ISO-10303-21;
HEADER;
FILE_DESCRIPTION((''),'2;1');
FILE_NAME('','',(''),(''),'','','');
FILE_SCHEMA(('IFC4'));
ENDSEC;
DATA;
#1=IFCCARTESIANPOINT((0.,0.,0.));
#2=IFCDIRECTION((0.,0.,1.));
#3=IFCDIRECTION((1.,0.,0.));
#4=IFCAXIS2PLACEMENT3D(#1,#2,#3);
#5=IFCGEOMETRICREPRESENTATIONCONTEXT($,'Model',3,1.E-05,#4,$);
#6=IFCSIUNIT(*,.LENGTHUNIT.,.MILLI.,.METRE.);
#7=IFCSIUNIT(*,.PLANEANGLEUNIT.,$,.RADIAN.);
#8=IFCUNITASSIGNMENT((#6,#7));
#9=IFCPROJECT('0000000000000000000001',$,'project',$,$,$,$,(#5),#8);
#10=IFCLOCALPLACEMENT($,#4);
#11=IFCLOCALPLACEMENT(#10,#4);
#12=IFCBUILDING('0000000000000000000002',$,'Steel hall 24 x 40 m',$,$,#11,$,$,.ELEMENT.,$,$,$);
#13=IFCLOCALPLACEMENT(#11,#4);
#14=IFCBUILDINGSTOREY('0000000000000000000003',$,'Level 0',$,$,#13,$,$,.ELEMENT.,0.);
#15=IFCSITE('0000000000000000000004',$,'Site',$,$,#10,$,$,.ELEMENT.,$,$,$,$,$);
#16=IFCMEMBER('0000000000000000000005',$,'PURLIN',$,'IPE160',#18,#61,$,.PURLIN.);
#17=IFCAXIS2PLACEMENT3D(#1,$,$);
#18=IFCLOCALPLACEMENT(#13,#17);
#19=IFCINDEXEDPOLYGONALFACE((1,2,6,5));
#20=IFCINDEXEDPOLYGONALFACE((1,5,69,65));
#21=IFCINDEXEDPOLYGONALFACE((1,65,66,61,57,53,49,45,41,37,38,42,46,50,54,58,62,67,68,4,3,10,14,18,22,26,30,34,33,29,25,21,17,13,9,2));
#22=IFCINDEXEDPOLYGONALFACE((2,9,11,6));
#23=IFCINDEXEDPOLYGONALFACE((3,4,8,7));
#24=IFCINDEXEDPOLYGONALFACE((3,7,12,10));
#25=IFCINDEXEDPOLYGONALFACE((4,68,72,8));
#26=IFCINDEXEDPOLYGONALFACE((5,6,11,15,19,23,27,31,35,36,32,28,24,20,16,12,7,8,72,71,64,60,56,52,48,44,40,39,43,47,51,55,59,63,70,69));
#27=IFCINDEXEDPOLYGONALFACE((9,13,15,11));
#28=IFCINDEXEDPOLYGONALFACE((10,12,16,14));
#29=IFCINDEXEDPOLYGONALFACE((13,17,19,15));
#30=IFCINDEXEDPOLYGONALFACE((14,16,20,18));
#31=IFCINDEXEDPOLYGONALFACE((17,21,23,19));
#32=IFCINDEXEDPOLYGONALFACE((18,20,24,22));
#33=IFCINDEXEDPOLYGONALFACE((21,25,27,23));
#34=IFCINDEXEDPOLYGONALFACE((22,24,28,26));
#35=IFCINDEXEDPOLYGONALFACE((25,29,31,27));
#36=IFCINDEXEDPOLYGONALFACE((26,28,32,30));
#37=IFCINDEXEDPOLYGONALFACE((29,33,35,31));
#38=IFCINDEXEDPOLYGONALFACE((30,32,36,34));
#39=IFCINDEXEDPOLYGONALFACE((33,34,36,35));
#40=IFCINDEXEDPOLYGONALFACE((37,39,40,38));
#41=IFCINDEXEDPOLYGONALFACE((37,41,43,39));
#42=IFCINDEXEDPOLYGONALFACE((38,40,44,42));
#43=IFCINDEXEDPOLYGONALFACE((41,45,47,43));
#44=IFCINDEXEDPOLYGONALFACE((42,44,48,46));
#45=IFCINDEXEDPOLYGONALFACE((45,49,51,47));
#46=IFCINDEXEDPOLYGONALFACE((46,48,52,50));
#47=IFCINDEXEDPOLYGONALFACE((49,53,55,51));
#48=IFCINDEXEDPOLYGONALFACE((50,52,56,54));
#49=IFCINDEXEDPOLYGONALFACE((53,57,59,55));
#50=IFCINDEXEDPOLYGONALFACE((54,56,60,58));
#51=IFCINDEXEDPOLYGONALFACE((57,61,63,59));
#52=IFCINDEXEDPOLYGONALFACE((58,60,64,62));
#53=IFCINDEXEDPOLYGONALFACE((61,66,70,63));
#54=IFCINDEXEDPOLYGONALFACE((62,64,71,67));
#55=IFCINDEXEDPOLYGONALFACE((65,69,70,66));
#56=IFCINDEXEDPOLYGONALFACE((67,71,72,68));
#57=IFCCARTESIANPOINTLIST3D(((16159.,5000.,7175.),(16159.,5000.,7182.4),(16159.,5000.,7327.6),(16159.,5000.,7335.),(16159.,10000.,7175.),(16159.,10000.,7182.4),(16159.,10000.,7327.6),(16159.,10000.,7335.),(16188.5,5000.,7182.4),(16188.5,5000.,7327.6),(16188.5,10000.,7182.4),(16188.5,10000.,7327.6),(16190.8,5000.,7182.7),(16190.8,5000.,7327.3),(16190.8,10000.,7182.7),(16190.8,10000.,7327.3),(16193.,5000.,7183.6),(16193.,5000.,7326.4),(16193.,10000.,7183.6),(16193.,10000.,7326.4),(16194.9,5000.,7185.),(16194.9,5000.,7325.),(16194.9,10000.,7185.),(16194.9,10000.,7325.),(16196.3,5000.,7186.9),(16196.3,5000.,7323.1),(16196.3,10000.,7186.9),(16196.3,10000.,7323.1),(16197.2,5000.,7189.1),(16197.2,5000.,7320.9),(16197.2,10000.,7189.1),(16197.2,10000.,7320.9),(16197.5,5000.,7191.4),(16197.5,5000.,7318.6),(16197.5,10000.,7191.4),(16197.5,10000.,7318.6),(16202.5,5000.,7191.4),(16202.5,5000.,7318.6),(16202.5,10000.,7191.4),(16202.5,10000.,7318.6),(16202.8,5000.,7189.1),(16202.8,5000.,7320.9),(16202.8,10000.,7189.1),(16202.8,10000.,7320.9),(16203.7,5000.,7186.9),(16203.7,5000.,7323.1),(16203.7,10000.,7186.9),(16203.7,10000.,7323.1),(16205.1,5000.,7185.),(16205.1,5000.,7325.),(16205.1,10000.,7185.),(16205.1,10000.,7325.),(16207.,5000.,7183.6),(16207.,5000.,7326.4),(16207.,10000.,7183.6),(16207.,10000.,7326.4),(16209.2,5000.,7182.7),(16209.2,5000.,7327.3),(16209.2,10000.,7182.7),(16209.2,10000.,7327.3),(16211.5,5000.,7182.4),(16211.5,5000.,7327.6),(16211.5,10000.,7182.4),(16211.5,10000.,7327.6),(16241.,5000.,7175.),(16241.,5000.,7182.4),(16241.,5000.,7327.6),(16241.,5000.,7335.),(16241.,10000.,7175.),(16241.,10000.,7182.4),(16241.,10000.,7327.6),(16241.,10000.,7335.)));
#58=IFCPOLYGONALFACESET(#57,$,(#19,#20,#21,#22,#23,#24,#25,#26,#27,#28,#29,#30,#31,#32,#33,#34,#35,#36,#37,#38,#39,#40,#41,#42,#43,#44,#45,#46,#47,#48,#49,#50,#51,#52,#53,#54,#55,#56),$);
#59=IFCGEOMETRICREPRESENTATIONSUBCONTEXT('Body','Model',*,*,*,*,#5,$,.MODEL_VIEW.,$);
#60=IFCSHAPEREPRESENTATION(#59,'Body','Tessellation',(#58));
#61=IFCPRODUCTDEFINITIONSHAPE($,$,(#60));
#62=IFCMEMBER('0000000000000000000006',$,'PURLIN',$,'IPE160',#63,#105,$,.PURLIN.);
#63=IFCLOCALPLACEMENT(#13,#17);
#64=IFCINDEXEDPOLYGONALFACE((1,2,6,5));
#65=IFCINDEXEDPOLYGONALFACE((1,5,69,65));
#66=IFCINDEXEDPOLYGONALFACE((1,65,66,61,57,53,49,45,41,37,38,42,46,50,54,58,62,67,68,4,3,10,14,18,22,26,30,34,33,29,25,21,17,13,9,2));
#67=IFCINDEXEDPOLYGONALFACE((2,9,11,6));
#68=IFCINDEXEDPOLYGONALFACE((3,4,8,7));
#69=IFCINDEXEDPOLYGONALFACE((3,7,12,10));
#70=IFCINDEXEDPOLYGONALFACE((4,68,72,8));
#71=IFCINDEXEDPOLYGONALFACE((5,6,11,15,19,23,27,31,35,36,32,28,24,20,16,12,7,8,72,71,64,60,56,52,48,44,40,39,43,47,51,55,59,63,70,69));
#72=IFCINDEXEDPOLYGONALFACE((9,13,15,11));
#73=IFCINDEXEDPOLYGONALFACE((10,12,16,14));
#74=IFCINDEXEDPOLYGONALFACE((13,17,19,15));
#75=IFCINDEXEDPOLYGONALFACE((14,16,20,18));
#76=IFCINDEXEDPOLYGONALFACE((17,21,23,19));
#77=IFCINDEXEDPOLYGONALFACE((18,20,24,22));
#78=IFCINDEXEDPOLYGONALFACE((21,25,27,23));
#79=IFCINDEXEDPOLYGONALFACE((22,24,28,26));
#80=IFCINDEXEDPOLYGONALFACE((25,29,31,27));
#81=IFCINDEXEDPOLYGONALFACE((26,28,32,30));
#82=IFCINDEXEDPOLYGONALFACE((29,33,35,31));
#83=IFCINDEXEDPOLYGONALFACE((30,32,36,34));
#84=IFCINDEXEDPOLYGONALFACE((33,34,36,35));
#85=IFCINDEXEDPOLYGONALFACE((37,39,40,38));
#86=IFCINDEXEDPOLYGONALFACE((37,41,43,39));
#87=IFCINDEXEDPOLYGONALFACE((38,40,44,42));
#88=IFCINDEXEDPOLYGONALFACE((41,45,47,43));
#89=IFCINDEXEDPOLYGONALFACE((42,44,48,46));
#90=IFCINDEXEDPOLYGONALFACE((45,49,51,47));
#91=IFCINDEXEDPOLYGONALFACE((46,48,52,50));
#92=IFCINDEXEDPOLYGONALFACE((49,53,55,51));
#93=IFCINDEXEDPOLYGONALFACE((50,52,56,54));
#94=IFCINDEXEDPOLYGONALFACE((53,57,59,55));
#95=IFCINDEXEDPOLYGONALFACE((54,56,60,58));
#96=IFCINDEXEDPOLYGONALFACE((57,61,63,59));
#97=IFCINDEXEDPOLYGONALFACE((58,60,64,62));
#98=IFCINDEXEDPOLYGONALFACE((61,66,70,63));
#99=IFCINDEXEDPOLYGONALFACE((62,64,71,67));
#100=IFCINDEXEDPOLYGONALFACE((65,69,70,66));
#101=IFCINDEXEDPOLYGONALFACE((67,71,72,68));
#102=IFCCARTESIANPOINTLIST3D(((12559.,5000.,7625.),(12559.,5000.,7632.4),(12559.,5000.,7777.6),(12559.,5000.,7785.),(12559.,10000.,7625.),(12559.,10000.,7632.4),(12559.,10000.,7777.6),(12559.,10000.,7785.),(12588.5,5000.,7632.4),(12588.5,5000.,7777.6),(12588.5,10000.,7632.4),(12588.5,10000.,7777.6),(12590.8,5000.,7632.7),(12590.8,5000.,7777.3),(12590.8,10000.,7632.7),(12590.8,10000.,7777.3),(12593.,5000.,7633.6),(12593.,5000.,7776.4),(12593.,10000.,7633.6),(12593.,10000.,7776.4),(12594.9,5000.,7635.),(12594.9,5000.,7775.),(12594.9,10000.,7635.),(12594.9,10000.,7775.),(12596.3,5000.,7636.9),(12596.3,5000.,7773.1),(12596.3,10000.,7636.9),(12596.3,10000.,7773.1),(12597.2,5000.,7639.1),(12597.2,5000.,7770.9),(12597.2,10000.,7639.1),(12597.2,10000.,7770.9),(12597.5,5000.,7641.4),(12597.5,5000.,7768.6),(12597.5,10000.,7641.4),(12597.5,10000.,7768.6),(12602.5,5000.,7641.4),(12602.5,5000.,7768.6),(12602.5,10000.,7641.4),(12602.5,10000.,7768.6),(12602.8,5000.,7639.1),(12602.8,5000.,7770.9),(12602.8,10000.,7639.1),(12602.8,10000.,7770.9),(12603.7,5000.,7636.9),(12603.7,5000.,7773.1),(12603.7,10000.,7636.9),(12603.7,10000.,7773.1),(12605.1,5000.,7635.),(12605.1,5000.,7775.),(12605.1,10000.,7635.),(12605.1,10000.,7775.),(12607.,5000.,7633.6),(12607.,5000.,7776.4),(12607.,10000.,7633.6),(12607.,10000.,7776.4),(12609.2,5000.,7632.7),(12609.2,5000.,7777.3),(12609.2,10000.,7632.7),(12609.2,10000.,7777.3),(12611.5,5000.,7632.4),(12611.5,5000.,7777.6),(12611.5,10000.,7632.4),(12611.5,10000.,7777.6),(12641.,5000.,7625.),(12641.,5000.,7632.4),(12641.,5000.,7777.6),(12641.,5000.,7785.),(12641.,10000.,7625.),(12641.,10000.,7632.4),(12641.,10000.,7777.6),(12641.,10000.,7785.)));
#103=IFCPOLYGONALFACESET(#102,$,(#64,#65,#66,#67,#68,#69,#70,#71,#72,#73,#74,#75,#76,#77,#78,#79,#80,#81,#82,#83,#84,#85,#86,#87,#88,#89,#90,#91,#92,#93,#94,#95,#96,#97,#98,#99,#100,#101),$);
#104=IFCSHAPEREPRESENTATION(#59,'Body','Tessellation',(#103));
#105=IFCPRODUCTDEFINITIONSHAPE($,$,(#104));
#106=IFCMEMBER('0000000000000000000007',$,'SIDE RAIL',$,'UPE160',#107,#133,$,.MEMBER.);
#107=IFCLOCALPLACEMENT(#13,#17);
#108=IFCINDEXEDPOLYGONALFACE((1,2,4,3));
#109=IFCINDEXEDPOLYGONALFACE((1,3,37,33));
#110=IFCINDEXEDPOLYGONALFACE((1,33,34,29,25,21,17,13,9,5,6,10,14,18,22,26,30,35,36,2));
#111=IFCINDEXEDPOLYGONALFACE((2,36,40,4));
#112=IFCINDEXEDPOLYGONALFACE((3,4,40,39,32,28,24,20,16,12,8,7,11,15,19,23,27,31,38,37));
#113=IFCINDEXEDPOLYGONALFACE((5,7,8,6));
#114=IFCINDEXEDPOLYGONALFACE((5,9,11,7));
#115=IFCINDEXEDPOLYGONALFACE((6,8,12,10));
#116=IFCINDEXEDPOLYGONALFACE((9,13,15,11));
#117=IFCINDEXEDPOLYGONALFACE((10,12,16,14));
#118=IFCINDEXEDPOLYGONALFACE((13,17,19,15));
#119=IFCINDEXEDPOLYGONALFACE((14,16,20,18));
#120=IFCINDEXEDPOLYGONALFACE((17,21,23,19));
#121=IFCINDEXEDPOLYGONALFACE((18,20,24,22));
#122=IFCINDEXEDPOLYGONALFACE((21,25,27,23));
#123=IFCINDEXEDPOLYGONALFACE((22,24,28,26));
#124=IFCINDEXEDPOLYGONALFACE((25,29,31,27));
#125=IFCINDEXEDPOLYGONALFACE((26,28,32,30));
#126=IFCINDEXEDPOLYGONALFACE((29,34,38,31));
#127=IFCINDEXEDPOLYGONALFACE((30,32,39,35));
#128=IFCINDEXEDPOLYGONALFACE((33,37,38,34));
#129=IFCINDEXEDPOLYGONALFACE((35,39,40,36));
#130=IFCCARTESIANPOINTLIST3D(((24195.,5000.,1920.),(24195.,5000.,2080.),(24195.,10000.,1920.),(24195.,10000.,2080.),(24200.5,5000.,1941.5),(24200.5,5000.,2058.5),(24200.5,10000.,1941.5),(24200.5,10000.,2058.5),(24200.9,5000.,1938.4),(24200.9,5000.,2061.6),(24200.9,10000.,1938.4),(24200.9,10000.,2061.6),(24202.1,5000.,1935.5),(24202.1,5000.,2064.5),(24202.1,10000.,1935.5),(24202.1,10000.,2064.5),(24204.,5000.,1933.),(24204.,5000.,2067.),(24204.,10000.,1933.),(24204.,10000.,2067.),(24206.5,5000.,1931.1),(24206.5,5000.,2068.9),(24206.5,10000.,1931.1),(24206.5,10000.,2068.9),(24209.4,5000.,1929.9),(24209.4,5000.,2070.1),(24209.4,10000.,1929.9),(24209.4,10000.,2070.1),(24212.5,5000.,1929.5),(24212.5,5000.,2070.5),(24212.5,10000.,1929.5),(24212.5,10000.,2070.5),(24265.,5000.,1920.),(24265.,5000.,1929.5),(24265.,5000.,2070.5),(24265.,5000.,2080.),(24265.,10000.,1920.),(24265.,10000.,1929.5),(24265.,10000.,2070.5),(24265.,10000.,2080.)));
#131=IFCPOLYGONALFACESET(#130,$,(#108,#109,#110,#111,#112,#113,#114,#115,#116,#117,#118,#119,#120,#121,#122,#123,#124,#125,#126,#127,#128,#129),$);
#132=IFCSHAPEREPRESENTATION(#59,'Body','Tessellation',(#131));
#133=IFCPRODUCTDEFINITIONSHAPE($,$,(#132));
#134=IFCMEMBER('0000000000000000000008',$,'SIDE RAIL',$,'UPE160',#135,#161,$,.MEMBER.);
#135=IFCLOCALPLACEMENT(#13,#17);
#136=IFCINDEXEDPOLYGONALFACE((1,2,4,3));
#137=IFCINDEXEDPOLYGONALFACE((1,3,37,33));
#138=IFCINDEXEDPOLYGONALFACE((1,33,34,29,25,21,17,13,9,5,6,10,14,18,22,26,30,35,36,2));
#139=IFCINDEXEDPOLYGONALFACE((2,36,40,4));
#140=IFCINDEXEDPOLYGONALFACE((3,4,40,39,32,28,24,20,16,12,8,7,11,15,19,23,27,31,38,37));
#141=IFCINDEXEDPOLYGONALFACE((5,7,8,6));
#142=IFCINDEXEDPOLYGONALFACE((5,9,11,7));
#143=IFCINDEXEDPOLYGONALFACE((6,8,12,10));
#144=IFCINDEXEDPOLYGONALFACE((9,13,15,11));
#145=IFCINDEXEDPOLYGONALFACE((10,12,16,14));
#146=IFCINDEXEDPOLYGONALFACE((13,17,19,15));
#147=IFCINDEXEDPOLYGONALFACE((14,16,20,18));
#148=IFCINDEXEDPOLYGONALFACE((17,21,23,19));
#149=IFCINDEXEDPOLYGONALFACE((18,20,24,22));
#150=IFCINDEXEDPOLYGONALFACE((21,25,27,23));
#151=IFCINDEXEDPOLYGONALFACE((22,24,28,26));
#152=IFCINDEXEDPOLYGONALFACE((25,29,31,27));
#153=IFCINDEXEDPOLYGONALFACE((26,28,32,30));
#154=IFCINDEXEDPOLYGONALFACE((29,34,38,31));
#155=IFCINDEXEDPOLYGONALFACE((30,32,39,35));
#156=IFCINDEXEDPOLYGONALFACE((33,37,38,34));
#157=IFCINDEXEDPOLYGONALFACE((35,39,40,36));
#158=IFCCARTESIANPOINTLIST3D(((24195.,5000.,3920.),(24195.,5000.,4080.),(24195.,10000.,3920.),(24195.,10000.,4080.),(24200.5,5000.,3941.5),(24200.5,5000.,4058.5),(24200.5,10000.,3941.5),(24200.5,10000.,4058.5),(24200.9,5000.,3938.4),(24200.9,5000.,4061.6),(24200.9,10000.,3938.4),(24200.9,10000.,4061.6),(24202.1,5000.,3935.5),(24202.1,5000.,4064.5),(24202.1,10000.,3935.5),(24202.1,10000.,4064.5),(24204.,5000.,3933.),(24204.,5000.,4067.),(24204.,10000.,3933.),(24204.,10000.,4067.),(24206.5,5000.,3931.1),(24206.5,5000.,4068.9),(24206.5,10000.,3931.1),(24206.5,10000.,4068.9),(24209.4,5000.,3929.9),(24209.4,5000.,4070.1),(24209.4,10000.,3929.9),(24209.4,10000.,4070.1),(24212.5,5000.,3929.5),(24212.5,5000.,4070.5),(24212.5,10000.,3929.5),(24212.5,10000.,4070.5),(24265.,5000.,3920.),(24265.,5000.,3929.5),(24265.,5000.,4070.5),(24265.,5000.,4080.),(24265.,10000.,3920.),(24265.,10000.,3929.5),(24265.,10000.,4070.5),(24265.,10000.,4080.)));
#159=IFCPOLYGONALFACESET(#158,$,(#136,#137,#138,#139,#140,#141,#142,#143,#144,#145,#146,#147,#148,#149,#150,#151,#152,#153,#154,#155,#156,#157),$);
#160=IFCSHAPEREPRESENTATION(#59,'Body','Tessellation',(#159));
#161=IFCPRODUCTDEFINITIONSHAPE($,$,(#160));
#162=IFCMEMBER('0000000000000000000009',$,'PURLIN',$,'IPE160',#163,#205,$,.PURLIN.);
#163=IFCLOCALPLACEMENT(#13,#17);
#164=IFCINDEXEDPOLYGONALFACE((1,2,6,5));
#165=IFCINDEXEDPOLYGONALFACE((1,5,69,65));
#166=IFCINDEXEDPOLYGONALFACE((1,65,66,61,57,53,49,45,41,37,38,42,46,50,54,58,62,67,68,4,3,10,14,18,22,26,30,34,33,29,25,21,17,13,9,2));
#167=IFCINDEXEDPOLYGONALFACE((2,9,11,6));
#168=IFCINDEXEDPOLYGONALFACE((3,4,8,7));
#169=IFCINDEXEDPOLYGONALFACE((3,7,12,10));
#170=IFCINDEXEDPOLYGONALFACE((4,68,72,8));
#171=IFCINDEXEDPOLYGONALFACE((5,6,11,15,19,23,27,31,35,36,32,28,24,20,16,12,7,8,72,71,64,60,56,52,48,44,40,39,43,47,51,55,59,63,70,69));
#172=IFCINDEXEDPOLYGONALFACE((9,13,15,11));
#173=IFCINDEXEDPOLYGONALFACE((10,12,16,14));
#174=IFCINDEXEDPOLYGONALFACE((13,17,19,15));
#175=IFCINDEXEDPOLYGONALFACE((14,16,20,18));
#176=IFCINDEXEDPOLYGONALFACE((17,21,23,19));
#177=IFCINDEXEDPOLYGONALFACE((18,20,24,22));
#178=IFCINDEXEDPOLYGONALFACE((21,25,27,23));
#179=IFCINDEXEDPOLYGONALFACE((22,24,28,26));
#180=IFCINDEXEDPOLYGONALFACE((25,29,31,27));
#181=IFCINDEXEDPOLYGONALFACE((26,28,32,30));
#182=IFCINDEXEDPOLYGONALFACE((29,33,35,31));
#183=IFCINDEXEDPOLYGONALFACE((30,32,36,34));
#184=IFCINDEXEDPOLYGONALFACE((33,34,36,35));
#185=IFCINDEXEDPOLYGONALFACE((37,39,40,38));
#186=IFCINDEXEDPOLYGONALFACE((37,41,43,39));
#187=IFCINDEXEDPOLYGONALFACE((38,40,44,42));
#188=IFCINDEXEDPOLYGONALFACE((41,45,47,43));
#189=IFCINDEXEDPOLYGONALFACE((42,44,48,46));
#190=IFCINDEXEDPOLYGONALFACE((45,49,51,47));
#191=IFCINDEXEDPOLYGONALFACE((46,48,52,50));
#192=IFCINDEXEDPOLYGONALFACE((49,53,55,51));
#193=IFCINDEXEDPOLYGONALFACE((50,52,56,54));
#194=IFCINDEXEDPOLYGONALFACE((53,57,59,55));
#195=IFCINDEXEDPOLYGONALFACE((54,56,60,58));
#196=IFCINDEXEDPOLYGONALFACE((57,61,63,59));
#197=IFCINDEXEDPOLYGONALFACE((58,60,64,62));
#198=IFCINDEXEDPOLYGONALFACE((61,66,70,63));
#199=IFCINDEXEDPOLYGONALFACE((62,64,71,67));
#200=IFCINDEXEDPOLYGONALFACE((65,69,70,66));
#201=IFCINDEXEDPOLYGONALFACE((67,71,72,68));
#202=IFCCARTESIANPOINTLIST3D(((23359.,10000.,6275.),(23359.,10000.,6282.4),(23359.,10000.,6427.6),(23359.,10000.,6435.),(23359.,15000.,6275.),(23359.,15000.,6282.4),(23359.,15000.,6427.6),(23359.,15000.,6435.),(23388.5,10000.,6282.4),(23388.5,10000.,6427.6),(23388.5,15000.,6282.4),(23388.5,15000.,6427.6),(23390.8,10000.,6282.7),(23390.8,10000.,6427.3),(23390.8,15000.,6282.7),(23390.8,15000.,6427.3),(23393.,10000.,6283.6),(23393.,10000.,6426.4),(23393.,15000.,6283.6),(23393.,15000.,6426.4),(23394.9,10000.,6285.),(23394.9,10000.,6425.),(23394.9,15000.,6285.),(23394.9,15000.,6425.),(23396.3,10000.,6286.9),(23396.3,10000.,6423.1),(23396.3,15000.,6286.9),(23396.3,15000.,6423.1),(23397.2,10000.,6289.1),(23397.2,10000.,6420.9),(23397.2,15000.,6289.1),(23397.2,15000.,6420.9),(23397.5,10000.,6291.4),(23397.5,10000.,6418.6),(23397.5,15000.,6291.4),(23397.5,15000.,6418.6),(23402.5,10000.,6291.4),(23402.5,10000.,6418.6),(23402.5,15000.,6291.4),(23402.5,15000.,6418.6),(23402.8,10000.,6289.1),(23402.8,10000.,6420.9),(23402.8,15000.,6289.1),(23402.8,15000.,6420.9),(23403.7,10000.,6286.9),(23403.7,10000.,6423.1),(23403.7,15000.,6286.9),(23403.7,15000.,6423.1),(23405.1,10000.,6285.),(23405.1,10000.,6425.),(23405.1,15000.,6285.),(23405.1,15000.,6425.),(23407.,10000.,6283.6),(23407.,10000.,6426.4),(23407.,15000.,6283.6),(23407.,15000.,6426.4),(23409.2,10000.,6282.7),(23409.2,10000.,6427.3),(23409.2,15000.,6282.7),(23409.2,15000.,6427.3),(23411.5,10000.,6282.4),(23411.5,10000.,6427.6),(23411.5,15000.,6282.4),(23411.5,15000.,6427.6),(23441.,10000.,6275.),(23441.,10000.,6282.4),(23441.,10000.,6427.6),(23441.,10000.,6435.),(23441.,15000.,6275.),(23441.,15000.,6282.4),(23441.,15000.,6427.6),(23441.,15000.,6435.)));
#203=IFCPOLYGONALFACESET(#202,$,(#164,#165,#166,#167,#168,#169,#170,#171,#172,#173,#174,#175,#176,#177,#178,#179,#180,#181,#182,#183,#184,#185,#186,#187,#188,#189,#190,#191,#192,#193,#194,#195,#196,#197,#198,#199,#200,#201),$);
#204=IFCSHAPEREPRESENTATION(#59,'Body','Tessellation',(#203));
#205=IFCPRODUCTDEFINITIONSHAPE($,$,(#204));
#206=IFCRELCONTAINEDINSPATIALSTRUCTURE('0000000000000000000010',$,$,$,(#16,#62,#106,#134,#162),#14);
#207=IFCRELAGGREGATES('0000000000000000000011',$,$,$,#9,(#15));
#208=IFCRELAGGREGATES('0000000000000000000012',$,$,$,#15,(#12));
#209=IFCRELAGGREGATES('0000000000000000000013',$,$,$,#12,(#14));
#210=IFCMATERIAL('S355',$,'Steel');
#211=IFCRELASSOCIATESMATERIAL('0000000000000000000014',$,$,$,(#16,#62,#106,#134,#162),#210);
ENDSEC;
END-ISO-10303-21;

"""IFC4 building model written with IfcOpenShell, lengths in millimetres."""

from ifc_helpers import new_model, si_unit, frame, origin_with_axes, place, context, subcontext, project, spatial, i_section, u_section, extrude, material, element, save


model = new_model("IFC4")

# Units and contexts
model_context = context("Model", 3, precision=1e-05, world=origin_with_axes())
body_context = subcontext(model_context, "Body", "Model", "MODEL_VIEW")
ifc_project = project(units=[si_unit("LENGTHUNIT", "METRE", prefix="MILLI"), si_unit("PLANEANGLEUNIT", "RADIAN")], contexts=[model_context])

# Site, building, storey
site_placement = place(None, origin_with_axes())
site = spatial("IfcSite", under=ifc_project, at=site_placement, Name="Site", CompositionType="ELEMENT")
building_placement = place(site_placement, origin_with_axes())
building = spatial("IfcBuilding", under=site, at=building_placement, Name="Steel hall 24 x 40 m", CompositionType="ELEMENT")
storey_placement = place(building_placement, origin_with_axes())
storey = spatial("IfcBuildingStorey", under=building, at=storey_placement, Name="Level 0", CompositionType="ELEMENT", Elevation=0.0)

# Shared definitions
ifc_material = material(Name="S355", Category="Steel")

# Members
for number, where, z_axis, x_axis, name in (
    (1, (16200.0, 5000.0, 7255.0), (0.0, 1.0, 0.0), (1.0, 0.0, 0.0), "PURLIN"),
    (2, (12600.0, 5000.0, 7705.0), (0.0, 1.0, 0.0), (1.0, 0.0, 0.0), "PURLIN"),
):
    element("IfcMember", number, at=place(storey_placement, frame(where, z_axis=z_axis, x_axis=x_axis)), inside=storey, material=ifc_material, Name=name, ObjectType="IPE160", PredefinedType="PURLIN", context=body_context, shape_type="SweptSolid", body=[
        extrude(i_section(OverallWidth=82.0, OverallDepth=160.0, WebThickness=5.0, FlangeThickness=7.4, FilletRadius=9.0), origin_with_axes(), (0.0, 0.0, 1.0), 5000.0),
    ])
for number, where, z_axis, x_axis, name in (
    (3, (24230.0, 5000.0, 2000.0), (0.0, 1.0, 0.0), (1.0, 0.0, 0.0), "SIDE RAIL"),
    (4, (24230.0, 5000.0, 4000.0), (0.0, 1.0, 0.0), (1.0, 0.0, 0.0), "SIDE RAIL"),
):
    element("IfcMember", number, at=place(storey_placement, frame(where, z_axis=z_axis, x_axis=x_axis)), inside=storey, material=ifc_material, Name=name, ObjectType="UPE160", PredefinedType="MEMBER", context=body_context, shape_type="SweptSolid", body=[
        extrude(u_section(Depth=160.0, FlangeWidth=70.0, WebThickness=5.5, FlangeThickness=9.5, FilletRadius=12.0), origin_with_axes(), (0.0, 0.0, 1.0), 5000.0),
    ])
for number, where, z_axis, x_axis, name in (
    (5, (23400.0, 10000.0, 6355.0), (0.0, 1.0, 0.0), (1.0, 0.0, 0.0), "PURLIN"),
):
    element("IfcMember", number, at=place(storey_placement, frame(where, z_axis=z_axis, x_axis=x_axis)), inside=storey, material=ifc_material, Name=name, ObjectType="IPE160", PredefinedType="PURLIN", context=body_context, shape_type="SweptSolid", body=[
        extrude(i_section(OverallWidth=82.0, OverallDepth=160.0, WebThickness=5.0, FlangeThickness=7.4, FilletRadius=9.0), origin_with_axes(), (0.0, 0.0, 1.0), 5000.0),
    ])

save(model, "model.ifc")
